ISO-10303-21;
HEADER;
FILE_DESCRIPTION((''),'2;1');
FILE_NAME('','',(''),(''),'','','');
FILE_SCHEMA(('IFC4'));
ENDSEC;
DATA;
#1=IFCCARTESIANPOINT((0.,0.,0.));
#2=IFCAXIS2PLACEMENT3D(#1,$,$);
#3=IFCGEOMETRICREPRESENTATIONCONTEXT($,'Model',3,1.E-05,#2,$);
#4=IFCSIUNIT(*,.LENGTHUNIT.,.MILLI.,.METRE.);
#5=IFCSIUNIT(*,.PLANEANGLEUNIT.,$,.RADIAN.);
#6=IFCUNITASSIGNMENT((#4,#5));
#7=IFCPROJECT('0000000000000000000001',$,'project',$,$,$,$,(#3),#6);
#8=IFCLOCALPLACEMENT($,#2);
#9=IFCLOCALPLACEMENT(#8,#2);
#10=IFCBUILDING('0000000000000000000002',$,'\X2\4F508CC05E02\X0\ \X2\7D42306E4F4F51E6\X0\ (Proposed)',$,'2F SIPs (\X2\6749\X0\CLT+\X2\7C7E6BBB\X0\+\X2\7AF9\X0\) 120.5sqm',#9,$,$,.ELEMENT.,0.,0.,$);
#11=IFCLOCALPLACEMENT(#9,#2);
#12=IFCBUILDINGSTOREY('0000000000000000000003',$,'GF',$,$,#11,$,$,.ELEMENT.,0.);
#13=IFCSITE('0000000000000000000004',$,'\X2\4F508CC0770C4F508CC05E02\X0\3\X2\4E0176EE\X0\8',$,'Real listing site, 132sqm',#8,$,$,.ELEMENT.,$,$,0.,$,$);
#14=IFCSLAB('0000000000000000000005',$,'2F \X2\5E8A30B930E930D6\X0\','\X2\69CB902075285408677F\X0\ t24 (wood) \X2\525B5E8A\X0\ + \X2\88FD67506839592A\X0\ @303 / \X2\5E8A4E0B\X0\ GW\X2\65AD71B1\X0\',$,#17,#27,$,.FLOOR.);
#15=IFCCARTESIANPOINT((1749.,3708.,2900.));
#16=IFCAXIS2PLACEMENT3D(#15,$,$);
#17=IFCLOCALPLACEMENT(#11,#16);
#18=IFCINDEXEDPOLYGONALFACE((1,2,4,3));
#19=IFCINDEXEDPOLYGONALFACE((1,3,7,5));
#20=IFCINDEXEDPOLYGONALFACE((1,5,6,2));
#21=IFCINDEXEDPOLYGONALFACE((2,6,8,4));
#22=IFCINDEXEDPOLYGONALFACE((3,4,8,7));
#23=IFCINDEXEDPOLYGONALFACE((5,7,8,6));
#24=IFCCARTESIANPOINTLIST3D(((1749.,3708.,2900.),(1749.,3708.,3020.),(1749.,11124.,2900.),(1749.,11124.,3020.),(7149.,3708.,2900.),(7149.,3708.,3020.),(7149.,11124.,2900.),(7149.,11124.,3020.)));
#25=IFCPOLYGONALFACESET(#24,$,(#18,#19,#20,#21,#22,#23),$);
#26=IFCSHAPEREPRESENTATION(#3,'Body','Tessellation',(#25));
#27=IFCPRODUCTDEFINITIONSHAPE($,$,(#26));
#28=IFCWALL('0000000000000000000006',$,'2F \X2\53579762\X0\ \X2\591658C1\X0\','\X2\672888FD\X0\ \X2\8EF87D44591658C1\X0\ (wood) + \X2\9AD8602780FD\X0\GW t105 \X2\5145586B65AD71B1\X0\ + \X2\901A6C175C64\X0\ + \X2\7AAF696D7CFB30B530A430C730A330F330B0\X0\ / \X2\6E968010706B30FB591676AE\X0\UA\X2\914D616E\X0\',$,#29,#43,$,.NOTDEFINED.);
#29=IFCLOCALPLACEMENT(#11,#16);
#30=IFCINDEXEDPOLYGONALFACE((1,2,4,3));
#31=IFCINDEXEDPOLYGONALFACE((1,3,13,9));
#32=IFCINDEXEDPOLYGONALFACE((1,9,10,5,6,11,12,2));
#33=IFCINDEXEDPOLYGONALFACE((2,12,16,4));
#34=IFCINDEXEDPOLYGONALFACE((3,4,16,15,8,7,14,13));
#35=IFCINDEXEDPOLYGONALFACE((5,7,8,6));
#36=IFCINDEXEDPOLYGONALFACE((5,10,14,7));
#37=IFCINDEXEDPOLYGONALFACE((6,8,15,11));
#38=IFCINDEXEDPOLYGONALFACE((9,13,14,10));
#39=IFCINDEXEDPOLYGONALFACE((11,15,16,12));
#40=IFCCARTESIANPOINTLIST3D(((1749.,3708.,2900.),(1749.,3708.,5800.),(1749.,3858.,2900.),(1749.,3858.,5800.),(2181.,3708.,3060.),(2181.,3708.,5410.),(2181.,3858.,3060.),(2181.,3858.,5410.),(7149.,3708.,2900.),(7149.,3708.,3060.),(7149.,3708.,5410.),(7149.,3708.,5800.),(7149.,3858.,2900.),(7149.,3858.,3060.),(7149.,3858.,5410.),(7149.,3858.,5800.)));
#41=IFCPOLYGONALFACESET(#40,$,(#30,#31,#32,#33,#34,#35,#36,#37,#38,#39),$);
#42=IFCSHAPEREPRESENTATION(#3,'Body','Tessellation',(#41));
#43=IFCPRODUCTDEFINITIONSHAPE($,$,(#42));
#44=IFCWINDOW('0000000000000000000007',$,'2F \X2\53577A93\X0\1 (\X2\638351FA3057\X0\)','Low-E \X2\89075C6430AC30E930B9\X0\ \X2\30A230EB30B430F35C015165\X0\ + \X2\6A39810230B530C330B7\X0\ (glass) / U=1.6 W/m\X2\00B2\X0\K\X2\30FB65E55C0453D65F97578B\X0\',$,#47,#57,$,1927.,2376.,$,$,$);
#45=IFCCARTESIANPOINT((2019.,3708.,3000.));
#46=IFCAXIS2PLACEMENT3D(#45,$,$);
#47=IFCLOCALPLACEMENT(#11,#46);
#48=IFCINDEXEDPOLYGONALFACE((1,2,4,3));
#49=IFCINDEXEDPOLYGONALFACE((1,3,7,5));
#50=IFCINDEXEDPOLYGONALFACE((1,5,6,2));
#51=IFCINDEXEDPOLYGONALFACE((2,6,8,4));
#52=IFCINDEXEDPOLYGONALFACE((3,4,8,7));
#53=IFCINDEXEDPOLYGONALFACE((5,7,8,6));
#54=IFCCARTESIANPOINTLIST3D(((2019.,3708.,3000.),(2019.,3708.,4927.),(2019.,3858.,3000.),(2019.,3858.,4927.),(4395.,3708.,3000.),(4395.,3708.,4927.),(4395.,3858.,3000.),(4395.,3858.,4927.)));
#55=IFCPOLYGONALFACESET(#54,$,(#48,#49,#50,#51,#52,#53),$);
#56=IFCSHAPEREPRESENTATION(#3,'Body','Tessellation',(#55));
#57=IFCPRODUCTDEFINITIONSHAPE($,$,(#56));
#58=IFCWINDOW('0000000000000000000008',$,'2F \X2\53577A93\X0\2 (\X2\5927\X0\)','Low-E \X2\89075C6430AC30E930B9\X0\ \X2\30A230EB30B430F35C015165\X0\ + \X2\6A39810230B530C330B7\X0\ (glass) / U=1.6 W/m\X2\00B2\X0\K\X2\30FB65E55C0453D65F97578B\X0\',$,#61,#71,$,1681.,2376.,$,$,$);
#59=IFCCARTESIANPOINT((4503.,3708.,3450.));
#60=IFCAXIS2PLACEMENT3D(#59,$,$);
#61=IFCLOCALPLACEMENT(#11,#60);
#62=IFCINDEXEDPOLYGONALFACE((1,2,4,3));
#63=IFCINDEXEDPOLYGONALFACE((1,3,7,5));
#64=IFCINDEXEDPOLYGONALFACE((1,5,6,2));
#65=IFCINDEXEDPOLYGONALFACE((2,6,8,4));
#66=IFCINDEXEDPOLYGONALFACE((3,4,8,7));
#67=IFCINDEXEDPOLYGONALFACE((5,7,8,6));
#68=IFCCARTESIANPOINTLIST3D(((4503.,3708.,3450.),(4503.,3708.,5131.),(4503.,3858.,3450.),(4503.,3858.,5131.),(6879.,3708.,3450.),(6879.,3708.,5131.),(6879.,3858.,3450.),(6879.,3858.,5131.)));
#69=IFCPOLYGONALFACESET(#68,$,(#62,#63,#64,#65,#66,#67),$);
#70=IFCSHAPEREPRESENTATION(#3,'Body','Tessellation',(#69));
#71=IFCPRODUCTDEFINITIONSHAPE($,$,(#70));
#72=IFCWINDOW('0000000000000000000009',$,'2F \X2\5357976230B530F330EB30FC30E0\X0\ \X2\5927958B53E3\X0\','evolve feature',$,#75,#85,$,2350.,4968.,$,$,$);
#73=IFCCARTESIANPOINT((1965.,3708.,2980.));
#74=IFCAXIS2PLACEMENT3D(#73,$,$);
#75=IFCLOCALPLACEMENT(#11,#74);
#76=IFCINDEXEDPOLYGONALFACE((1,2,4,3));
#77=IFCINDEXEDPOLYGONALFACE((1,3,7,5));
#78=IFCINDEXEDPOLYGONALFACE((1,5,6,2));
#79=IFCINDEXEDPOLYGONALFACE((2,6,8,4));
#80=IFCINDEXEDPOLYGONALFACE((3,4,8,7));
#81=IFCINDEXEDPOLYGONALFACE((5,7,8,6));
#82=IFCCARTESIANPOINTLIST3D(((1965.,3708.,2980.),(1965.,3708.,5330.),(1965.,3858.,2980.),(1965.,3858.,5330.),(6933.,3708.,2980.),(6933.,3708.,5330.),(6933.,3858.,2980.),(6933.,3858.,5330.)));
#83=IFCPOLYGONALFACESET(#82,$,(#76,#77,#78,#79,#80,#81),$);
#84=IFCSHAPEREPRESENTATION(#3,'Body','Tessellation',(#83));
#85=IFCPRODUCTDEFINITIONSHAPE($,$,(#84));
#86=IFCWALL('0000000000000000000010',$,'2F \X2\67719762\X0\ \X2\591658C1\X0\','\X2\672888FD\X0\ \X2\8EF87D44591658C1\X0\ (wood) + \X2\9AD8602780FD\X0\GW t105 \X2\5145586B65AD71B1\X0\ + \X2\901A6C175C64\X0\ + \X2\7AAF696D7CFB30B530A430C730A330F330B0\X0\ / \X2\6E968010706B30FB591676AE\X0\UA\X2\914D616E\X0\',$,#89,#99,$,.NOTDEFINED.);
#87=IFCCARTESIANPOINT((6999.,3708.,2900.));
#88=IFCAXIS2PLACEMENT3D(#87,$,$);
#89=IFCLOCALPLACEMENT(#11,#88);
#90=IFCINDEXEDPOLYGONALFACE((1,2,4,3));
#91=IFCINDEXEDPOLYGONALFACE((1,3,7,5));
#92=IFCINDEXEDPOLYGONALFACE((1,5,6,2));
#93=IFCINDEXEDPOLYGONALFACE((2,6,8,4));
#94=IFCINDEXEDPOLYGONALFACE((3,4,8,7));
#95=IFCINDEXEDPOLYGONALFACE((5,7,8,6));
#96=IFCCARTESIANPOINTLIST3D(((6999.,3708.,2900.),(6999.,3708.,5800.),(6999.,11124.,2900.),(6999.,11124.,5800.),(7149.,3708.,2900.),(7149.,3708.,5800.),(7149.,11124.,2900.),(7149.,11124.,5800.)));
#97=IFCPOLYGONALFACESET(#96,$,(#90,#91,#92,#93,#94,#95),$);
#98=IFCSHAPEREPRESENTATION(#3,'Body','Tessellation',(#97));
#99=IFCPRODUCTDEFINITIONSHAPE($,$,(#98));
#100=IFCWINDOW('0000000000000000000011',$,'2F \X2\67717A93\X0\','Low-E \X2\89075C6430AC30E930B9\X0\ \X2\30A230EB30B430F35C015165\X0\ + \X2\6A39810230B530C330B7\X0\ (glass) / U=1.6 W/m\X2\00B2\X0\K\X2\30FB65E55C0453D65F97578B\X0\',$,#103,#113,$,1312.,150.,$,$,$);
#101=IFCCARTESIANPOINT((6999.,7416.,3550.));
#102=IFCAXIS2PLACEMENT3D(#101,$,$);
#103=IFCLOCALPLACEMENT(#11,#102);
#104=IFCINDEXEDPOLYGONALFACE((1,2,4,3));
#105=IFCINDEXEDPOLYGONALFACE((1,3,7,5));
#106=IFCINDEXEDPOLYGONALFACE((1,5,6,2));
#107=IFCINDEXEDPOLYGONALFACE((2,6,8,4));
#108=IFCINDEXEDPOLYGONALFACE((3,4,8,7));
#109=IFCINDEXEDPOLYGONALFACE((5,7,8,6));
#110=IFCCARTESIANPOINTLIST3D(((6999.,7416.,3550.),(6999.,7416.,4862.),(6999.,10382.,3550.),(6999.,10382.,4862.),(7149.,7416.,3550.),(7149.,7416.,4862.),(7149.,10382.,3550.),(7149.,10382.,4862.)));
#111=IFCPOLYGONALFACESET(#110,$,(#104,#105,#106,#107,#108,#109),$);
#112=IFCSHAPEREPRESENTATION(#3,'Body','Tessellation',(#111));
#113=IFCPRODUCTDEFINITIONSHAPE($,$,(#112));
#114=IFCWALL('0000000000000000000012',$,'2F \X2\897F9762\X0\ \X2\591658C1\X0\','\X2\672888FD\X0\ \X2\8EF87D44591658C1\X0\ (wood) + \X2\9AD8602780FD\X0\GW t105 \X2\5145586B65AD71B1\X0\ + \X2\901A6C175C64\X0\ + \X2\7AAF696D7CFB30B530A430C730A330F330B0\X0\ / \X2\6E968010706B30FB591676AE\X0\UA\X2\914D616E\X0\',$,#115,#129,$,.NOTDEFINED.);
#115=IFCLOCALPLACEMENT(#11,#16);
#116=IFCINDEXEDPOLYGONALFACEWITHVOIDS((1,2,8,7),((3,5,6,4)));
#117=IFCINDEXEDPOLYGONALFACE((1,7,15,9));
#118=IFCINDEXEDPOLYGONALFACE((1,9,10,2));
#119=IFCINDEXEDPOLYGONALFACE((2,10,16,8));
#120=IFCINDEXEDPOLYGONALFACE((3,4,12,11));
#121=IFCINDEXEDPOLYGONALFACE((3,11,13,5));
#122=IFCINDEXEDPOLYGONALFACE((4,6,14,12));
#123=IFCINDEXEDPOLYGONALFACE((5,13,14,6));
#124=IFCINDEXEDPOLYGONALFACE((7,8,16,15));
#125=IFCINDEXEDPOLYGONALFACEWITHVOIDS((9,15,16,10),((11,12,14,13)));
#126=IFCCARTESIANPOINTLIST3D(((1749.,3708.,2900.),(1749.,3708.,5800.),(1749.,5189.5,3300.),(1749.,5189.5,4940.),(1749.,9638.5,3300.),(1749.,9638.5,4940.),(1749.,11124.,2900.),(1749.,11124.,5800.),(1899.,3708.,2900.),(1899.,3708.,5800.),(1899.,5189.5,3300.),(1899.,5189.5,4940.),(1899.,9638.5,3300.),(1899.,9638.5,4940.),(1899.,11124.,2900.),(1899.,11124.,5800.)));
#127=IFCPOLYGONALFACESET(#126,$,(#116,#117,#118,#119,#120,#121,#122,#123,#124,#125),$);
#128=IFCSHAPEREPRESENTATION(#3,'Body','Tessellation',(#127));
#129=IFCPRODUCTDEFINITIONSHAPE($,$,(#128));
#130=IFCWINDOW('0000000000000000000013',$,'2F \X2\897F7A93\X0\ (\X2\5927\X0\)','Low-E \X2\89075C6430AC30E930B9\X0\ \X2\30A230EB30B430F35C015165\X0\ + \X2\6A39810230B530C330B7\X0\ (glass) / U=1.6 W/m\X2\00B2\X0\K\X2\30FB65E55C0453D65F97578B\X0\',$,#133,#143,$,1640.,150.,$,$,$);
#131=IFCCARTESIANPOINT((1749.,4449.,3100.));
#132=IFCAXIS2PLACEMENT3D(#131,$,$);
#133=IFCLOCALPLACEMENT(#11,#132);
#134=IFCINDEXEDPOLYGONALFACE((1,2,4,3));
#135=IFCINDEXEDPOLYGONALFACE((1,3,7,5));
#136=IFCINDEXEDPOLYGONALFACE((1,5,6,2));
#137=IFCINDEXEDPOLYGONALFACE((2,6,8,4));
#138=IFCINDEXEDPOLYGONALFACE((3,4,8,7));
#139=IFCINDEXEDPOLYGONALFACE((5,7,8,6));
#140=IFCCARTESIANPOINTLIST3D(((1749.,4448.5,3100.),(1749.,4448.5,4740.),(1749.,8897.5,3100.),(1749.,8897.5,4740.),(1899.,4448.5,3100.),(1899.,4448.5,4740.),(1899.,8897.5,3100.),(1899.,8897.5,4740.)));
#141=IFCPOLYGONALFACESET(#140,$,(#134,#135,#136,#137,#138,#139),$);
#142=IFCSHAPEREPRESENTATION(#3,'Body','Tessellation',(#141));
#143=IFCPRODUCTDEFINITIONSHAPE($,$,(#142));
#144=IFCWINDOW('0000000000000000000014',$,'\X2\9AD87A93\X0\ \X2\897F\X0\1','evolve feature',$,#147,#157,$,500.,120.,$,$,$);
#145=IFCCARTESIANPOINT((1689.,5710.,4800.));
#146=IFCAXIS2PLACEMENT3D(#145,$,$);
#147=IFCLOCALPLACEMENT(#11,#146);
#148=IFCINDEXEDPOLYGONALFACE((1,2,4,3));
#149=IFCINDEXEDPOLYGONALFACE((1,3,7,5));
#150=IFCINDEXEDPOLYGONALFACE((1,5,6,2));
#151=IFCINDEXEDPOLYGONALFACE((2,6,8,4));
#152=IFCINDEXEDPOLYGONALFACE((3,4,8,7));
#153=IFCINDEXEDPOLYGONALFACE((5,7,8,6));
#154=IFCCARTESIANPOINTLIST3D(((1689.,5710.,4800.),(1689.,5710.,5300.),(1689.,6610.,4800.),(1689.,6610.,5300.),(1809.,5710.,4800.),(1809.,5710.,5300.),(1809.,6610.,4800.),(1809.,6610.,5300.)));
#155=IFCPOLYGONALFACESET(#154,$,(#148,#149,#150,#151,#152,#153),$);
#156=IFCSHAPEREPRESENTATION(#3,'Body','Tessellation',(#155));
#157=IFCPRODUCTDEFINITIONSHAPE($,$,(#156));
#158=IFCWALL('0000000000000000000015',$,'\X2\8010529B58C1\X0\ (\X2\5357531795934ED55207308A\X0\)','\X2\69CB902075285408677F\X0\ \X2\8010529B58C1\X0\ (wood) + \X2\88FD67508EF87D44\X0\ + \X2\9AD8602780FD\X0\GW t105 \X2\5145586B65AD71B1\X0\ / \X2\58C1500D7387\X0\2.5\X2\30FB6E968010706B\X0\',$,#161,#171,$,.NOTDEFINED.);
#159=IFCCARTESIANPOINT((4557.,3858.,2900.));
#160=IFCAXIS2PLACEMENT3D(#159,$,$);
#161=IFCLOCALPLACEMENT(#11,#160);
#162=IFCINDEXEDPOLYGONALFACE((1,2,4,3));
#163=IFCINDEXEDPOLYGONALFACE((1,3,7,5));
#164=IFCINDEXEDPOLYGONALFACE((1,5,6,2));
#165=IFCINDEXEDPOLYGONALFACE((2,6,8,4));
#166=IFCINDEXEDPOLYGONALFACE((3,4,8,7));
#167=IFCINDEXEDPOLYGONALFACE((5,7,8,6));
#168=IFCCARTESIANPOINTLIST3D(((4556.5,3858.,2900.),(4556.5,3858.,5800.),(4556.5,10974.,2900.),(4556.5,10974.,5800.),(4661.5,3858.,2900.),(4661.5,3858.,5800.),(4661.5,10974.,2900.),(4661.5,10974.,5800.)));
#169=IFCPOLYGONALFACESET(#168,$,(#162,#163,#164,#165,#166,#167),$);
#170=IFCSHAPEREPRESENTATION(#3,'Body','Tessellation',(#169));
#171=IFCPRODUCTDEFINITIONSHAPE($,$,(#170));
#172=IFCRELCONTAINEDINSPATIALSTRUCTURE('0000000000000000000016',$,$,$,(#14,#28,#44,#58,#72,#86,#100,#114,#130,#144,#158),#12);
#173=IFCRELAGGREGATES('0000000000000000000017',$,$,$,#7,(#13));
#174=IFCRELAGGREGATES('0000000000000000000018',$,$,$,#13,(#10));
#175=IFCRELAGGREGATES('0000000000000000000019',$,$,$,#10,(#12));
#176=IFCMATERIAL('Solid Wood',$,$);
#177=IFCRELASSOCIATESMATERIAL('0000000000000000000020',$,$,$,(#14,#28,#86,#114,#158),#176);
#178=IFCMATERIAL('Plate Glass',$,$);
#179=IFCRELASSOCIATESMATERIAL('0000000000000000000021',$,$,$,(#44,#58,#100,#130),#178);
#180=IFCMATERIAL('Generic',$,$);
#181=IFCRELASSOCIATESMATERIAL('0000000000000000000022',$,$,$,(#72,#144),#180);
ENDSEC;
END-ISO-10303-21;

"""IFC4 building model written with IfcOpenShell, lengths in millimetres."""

from ifc_helpers import new_model, si_unit, frame, frame_2d, origin, place, context, project, spatial, rectangle, extrude, material, element, fill, save


model = new_model("IFC4")

# Units and contexts
model_context = context("Model", 3, precision=1e-05, world=origin())
ifc_project = project(units=[si_unit("LENGTHUNIT", "METRE", prefix="MILLI"), si_unit("PLANEANGLEUNIT", "RADIAN")], contexts=[model_context])

# Site, building, storey
site_placement = place(None, origin())
site = spatial("IfcSite", under=ifc_project, at=site_placement, Name="佐賀県佐賀市3丁目8", ObjectType="Real listing site, 132sqm", CompositionType="ELEMENT", RefElevation=0.0)
building_placement = place(site_placement, origin())
building = spatial("IfcBuilding", under=site, at=building_placement, Name="佐賀市 終の住処 (Proposed)", ObjectType="2F SIPs (杉CLT+籾殻+竹) 120.5sqm", CompositionType="ELEMENT", ElevationOfRefHeight=0.0, ElevationOfTerrain=0.0)
storey_placement = place(building_placement, origin())
storey = spatial("IfcBuildingStorey", under=building, at=storey_placement, Name="GF", CompositionType="ELEMENT", Elevation=0.0)

# Slab
ifc_material_1 = material(Name="Solid Wood")
slab_placement = place(storey_placement, frame((1749.0, 3708.0, 2900.0)))
element("IfcSlab", 1, at=slab_placement, inside=storey, material=ifc_material_1, Name="2F 床スラブ", Description="構造用合板 t24 (wood) 剛床 + 製材根太 @303 / 床下 GW断熱", PredefinedType="FLOOR", context=model_context, shape_type="SweptSolid", body=[
    extrude(rectangle(XDim=5400.0, YDim=7416.0, at=frame_2d((2700.0, 3708.0))), frame((1749.0, 3708.0, 2900.0)), (0.0, 0.0, 1.0), 120.0),
])

# Wall, openings, windows
wall_1_placement = place(storey_placement, frame((1749.0, 3708.0, 2900.0)))
wall_1 = element("IfcWall", 2, at=wall_1_placement, inside=storey, material=ifc_material_1, Name="2F 南面 外壁", Description="木製 軸組外壁 (wood) + 高性能GW t105 充填断熱 + 通気層 + 窯業系サイディング / 準耐火・外皮UA配慮", PredefinedType="NOTDEFINED", context=model_context, shape_type="SweptSolid", body=[
    extrude(rectangle(XDim=5400.0, YDim=150.0, at=frame_2d((2700.0, 75.0))), frame((1749.0, 3708.0, 2900.0)), (0.0, 0.0, 1.0), 2900.0),
])
opening_1_placement = place(storey_placement, frame((2019.0, 3708.0, 3000.0)))
opening_1 = element("IfcOpeningElement", 3, at=opening_1_placement, cuts=wall_1, PredefinedType="NOTDEFINED", context=model_context, shape_type="SweptSolid", body=[
    extrude(rectangle(XDim=2376.0, YDim=150.0, at=frame_2d((1188.0, 75.0))), frame((2019.0, 3708.0, 3000.0)), (0.0, 0.0, 1.0), 1927.0),
])
opening_2_placement = place(storey_placement, frame((4503.0, 3708.0, 3450.0)))
opening_2 = element("IfcOpeningElement", 4, at=opening_2_placement, cuts=wall_1, PredefinedType="NOTDEFINED", context=model_context, shape_type="SweptSolid", body=[
    extrude(rectangle(XDim=2376.0, YDim=150.0, at=frame_2d((1188.0, 75.0))), frame((4503.0, 3708.0, 3450.0)), (0.0, 0.0, 1.0), 1681.0),
])
opening_3_placement = place(storey_placement, frame((1965.0, 3708.0, 2980.0)))
opening_3 = element("IfcOpeningElement", 5, at=opening_3_placement, cuts=wall_1, PredefinedType="NOTDEFINED", context=model_context, shape_type="SweptSolid", body=[
    extrude(rectangle(XDim=4968.0, YDim=150.0, at=frame_2d((2484.0, 75.0))), frame((1965.0, 3708.0, 2980.0)), (0.0, 0.0, 1.0), 2350.0),
])
ifc_material_2 = material(Name="Plate Glass")
window_1_placement = place(storey_placement, frame((2019.0, 3708.0, 3000.0)))
window_1 = element("IfcWindow", 6, at=window_1_placement, inside=storey, material=ifc_material_2, Name="2F 南窓1 (掃出し)", Description="Low-E 複層ガラス アルゴン封入 + 樹脂サッシ (glass) / U=1.6 W/m²K・日射取得型", OverallHeight=1927.0, OverallWidth=2376.0, context=model_context, shape_type="SweptSolid", body=[
    extrude(rectangle(XDim=2376.0, YDim=150.0, at=frame_2d((1188.0, 75.0))), frame((2019.0, 3708.0, 3000.0)), (0.0, 0.0, 1.0), 1927.0),
])
fill(opening_1, window_1)
window_2_placement = place(storey_placement, frame((4503.0, 3708.0, 3450.0)))
window_2 = element("IfcWindow", 7, at=window_2_placement, inside=storey, material=ifc_material_2, Name="2F 南窓2 (大)", Description="Low-E 複層ガラス アルゴン封入 + 樹脂サッシ (glass) / U=1.6 W/m²K・日射取得型", OverallHeight=1681.0, OverallWidth=2376.0, context=model_context, shape_type="SweptSolid", body=[
    extrude(rectangle(XDim=2376.0, YDim=150.0, at=frame_2d((1188.0, 75.0))), frame((4503.0, 3708.0, 3450.0)), (0.0, 0.0, 1.0), 1681.0),
])
fill(opening_2, window_2)
ifc_material_3 = material(Name="Generic")
window_3_placement = place(storey_placement, frame((1965.0, 3708.0, 2980.0)))
window_3 = element("IfcWindow", 8, at=window_3_placement, inside=storey, material=ifc_material_3, Name="2F 南面サンルーム 大開口", Description="evolve feature", OverallHeight=2350.0, OverallWidth=4968.0, context=model_context, shape_type="SweptSolid", body=[
    extrude(rectangle(XDim=4968.0, YDim=150.0, at=frame_2d((2484.0, 75.0))), frame((1965.0, 3708.0, 2980.0)), (0.0, 0.0, 1.0), 2350.0),
])
fill(opening_3, window_3)

# Wall, opening, window
wall_2_placement = place(storey_placement, frame((6999.0, 3708.0, 2900.0)))
wall_2 = element("IfcWall", 9, at=wall_2_placement, inside=storey, material=ifc_material_1, Name="2F 東面 外壁", Description="木製 軸組外壁 (wood) + 高性能GW t105 充填断熱 + 通気層 + 窯業系サイディング / 準耐火・外皮UA配慮", PredefinedType="NOTDEFINED", context=model_context, shape_type="SweptSolid", body=[
    extrude(rectangle(XDim=150.0, YDim=7416.0, at=frame_2d((75.0, 3708.0))), frame((6999.0, 3708.0, 2900.0)), (0.0, 0.0, 1.0), 2900.0),
])
opening_4_placement = place(storey_placement, frame((6999.0, 7416.0, 3550.0)))
opening_4 = element("IfcOpeningElement", 10, at=opening_4_placement, cuts=wall_2, PredefinedType="NOTDEFINED", context=model_context, shape_type="SweptSolid", body=[
    extrude(rectangle(XDim=150.0, YDim=2966.0, at=frame_2d((75.0, 1483.0))), frame((6999.0, 7416.0, 3550.0)), (0.0, 0.0, 1.0), 1312.0),
])
window_4_placement = place(storey_placement, frame((6999.0, 7416.0, 3550.0)))
window_4 = element("IfcWindow", 11, at=window_4_placement, inside=storey, material=ifc_material_2, Name="2F 東窓", Description="Low-E 複層ガラス アルゴン封入 + 樹脂サッシ (glass) / U=1.6 W/m²K・日射取得型", OverallHeight=1312.0, OverallWidth=150.0, context=model_context, shape_type="SweptSolid", body=[
    extrude(rectangle(XDim=150.0, YDim=2966.0, at=frame_2d((75.0, 1483.0))), frame((6999.0, 7416.0, 3550.0)), (0.0, 0.0, 1.0), 1312.0),
])
fill(opening_4, window_4)

# Wall, openings, windows
wall_3_placement = place(storey_placement, frame((1749.0, 3708.0, 2900.0)))
wall_3 = element("IfcWall", 12, at=wall_3_placement, inside=storey, material=ifc_material_1, Name="2F 西面 外壁", Description="木製 軸組外壁 (wood) + 高性能GW t105 充填断熱 + 通気層 + 窯業系サイディング / 準耐火・外皮UA配慮", PredefinedType="NOTDEFINED", context=model_context, shape_type="SweptSolid", body=[
    extrude(rectangle(XDim=150.0, YDim=7416.0, at=frame_2d((75.0, 3708.0))), frame((1749.0, 3708.0, 2900.0)), (0.0, 0.0, 1.0), 2900.0),
])
opening_5_placement = place(storey_placement, frame((1749.0, 4449.0, 3100.0)))
opening_5 = element("IfcOpeningElement", 13, at=opening_5_placement, cuts=wall_3, PredefinedType="NOTDEFINED", context=model_context, shape_type="SweptSolid", body=[
    extrude(rectangle(XDim=150.0, YDim=4449.0, at=frame_2d((75.0, 2224.0))), frame((1749.0, 4449.0, 3100.0)), (0.0, 0.0, 1.0), 1640.0),
])
opening_6_placement = place(storey_placement, frame((1689.0, 5710.0, 4800.0)))
opening_6 = element("IfcOpeningElement", 14, at=opening_6_placement, cuts=wall_3, PredefinedType="NOTDEFINED", context=model_context, shape_type="SweptSolid", body=[
    extrude(rectangle(XDim=120.0, YDim=900.0, at=frame_2d((60.0, 450.0))), frame((1689.0, 5710.0, 4800.0)), (0.0, 0.0, 1.0), 500.0),
])
window_5_placement = place(storey_placement, frame((1749.0, 4449.0, 3100.0)))
window_5 = element("IfcWindow", 15, at=window_5_placement, inside=storey, material=ifc_material_2, Name="2F 西窓 (大)", Description="Low-E 複層ガラス アルゴン封入 + 樹脂サッシ (glass) / U=1.6 W/m²K・日射取得型", OverallHeight=1640.0, OverallWidth=150.0, context=model_context, shape_type="SweptSolid", body=[
    extrude(rectangle(XDim=150.0, YDim=4449.0, at=frame_2d((75.0, 2224.0))), frame((1749.0, 4449.0, 3100.0)), (0.0, 0.0, 1.0), 1640.0),
])
fill(opening_5, window_5)
window_6_placement = place(storey_placement, frame((1689.0, 5710.0, 4800.0)))
window_6 = element("IfcWindow", 16, at=window_6_placement, inside=storey, material=ifc_material_3, Name="高窓 西1", Description="evolve feature", OverallHeight=500.0, OverallWidth=120.0, context=model_context, shape_type="SweptSolid", body=[
    extrude(rectangle(XDim=120.0, YDim=900.0, at=frame_2d((60.0, 450.0))), frame((1689.0, 5710.0, 4800.0)), (0.0, 0.0, 1.0), 500.0),
])
fill(opening_6, window_6)

# Wall
wall_4_placement = place(storey_placement, frame((4557.0, 3858.0, 2900.0)))
element("IfcWall", 17, at=wall_4_placement, inside=storey, material=ifc_material_1, Name="耐力壁 (南北間仕切り)", Description="構造用合板 耐力壁 (wood) + 製材軸組 + 高性能GW t105 充填断熱 / 壁倍率2.5・準耐火", PredefinedType="NOTDEFINED", context=model_context, shape_type="SweptSolid", body=[
    extrude(rectangle(XDim=105.0, YDim=7116.0, at=frame_2d((52.0, 3558.0))), frame((4557.0, 3858.0, 2900.0)), (0.0, 0.0, 1.0), 2900.0),
])

save(model, "model.ifc")
